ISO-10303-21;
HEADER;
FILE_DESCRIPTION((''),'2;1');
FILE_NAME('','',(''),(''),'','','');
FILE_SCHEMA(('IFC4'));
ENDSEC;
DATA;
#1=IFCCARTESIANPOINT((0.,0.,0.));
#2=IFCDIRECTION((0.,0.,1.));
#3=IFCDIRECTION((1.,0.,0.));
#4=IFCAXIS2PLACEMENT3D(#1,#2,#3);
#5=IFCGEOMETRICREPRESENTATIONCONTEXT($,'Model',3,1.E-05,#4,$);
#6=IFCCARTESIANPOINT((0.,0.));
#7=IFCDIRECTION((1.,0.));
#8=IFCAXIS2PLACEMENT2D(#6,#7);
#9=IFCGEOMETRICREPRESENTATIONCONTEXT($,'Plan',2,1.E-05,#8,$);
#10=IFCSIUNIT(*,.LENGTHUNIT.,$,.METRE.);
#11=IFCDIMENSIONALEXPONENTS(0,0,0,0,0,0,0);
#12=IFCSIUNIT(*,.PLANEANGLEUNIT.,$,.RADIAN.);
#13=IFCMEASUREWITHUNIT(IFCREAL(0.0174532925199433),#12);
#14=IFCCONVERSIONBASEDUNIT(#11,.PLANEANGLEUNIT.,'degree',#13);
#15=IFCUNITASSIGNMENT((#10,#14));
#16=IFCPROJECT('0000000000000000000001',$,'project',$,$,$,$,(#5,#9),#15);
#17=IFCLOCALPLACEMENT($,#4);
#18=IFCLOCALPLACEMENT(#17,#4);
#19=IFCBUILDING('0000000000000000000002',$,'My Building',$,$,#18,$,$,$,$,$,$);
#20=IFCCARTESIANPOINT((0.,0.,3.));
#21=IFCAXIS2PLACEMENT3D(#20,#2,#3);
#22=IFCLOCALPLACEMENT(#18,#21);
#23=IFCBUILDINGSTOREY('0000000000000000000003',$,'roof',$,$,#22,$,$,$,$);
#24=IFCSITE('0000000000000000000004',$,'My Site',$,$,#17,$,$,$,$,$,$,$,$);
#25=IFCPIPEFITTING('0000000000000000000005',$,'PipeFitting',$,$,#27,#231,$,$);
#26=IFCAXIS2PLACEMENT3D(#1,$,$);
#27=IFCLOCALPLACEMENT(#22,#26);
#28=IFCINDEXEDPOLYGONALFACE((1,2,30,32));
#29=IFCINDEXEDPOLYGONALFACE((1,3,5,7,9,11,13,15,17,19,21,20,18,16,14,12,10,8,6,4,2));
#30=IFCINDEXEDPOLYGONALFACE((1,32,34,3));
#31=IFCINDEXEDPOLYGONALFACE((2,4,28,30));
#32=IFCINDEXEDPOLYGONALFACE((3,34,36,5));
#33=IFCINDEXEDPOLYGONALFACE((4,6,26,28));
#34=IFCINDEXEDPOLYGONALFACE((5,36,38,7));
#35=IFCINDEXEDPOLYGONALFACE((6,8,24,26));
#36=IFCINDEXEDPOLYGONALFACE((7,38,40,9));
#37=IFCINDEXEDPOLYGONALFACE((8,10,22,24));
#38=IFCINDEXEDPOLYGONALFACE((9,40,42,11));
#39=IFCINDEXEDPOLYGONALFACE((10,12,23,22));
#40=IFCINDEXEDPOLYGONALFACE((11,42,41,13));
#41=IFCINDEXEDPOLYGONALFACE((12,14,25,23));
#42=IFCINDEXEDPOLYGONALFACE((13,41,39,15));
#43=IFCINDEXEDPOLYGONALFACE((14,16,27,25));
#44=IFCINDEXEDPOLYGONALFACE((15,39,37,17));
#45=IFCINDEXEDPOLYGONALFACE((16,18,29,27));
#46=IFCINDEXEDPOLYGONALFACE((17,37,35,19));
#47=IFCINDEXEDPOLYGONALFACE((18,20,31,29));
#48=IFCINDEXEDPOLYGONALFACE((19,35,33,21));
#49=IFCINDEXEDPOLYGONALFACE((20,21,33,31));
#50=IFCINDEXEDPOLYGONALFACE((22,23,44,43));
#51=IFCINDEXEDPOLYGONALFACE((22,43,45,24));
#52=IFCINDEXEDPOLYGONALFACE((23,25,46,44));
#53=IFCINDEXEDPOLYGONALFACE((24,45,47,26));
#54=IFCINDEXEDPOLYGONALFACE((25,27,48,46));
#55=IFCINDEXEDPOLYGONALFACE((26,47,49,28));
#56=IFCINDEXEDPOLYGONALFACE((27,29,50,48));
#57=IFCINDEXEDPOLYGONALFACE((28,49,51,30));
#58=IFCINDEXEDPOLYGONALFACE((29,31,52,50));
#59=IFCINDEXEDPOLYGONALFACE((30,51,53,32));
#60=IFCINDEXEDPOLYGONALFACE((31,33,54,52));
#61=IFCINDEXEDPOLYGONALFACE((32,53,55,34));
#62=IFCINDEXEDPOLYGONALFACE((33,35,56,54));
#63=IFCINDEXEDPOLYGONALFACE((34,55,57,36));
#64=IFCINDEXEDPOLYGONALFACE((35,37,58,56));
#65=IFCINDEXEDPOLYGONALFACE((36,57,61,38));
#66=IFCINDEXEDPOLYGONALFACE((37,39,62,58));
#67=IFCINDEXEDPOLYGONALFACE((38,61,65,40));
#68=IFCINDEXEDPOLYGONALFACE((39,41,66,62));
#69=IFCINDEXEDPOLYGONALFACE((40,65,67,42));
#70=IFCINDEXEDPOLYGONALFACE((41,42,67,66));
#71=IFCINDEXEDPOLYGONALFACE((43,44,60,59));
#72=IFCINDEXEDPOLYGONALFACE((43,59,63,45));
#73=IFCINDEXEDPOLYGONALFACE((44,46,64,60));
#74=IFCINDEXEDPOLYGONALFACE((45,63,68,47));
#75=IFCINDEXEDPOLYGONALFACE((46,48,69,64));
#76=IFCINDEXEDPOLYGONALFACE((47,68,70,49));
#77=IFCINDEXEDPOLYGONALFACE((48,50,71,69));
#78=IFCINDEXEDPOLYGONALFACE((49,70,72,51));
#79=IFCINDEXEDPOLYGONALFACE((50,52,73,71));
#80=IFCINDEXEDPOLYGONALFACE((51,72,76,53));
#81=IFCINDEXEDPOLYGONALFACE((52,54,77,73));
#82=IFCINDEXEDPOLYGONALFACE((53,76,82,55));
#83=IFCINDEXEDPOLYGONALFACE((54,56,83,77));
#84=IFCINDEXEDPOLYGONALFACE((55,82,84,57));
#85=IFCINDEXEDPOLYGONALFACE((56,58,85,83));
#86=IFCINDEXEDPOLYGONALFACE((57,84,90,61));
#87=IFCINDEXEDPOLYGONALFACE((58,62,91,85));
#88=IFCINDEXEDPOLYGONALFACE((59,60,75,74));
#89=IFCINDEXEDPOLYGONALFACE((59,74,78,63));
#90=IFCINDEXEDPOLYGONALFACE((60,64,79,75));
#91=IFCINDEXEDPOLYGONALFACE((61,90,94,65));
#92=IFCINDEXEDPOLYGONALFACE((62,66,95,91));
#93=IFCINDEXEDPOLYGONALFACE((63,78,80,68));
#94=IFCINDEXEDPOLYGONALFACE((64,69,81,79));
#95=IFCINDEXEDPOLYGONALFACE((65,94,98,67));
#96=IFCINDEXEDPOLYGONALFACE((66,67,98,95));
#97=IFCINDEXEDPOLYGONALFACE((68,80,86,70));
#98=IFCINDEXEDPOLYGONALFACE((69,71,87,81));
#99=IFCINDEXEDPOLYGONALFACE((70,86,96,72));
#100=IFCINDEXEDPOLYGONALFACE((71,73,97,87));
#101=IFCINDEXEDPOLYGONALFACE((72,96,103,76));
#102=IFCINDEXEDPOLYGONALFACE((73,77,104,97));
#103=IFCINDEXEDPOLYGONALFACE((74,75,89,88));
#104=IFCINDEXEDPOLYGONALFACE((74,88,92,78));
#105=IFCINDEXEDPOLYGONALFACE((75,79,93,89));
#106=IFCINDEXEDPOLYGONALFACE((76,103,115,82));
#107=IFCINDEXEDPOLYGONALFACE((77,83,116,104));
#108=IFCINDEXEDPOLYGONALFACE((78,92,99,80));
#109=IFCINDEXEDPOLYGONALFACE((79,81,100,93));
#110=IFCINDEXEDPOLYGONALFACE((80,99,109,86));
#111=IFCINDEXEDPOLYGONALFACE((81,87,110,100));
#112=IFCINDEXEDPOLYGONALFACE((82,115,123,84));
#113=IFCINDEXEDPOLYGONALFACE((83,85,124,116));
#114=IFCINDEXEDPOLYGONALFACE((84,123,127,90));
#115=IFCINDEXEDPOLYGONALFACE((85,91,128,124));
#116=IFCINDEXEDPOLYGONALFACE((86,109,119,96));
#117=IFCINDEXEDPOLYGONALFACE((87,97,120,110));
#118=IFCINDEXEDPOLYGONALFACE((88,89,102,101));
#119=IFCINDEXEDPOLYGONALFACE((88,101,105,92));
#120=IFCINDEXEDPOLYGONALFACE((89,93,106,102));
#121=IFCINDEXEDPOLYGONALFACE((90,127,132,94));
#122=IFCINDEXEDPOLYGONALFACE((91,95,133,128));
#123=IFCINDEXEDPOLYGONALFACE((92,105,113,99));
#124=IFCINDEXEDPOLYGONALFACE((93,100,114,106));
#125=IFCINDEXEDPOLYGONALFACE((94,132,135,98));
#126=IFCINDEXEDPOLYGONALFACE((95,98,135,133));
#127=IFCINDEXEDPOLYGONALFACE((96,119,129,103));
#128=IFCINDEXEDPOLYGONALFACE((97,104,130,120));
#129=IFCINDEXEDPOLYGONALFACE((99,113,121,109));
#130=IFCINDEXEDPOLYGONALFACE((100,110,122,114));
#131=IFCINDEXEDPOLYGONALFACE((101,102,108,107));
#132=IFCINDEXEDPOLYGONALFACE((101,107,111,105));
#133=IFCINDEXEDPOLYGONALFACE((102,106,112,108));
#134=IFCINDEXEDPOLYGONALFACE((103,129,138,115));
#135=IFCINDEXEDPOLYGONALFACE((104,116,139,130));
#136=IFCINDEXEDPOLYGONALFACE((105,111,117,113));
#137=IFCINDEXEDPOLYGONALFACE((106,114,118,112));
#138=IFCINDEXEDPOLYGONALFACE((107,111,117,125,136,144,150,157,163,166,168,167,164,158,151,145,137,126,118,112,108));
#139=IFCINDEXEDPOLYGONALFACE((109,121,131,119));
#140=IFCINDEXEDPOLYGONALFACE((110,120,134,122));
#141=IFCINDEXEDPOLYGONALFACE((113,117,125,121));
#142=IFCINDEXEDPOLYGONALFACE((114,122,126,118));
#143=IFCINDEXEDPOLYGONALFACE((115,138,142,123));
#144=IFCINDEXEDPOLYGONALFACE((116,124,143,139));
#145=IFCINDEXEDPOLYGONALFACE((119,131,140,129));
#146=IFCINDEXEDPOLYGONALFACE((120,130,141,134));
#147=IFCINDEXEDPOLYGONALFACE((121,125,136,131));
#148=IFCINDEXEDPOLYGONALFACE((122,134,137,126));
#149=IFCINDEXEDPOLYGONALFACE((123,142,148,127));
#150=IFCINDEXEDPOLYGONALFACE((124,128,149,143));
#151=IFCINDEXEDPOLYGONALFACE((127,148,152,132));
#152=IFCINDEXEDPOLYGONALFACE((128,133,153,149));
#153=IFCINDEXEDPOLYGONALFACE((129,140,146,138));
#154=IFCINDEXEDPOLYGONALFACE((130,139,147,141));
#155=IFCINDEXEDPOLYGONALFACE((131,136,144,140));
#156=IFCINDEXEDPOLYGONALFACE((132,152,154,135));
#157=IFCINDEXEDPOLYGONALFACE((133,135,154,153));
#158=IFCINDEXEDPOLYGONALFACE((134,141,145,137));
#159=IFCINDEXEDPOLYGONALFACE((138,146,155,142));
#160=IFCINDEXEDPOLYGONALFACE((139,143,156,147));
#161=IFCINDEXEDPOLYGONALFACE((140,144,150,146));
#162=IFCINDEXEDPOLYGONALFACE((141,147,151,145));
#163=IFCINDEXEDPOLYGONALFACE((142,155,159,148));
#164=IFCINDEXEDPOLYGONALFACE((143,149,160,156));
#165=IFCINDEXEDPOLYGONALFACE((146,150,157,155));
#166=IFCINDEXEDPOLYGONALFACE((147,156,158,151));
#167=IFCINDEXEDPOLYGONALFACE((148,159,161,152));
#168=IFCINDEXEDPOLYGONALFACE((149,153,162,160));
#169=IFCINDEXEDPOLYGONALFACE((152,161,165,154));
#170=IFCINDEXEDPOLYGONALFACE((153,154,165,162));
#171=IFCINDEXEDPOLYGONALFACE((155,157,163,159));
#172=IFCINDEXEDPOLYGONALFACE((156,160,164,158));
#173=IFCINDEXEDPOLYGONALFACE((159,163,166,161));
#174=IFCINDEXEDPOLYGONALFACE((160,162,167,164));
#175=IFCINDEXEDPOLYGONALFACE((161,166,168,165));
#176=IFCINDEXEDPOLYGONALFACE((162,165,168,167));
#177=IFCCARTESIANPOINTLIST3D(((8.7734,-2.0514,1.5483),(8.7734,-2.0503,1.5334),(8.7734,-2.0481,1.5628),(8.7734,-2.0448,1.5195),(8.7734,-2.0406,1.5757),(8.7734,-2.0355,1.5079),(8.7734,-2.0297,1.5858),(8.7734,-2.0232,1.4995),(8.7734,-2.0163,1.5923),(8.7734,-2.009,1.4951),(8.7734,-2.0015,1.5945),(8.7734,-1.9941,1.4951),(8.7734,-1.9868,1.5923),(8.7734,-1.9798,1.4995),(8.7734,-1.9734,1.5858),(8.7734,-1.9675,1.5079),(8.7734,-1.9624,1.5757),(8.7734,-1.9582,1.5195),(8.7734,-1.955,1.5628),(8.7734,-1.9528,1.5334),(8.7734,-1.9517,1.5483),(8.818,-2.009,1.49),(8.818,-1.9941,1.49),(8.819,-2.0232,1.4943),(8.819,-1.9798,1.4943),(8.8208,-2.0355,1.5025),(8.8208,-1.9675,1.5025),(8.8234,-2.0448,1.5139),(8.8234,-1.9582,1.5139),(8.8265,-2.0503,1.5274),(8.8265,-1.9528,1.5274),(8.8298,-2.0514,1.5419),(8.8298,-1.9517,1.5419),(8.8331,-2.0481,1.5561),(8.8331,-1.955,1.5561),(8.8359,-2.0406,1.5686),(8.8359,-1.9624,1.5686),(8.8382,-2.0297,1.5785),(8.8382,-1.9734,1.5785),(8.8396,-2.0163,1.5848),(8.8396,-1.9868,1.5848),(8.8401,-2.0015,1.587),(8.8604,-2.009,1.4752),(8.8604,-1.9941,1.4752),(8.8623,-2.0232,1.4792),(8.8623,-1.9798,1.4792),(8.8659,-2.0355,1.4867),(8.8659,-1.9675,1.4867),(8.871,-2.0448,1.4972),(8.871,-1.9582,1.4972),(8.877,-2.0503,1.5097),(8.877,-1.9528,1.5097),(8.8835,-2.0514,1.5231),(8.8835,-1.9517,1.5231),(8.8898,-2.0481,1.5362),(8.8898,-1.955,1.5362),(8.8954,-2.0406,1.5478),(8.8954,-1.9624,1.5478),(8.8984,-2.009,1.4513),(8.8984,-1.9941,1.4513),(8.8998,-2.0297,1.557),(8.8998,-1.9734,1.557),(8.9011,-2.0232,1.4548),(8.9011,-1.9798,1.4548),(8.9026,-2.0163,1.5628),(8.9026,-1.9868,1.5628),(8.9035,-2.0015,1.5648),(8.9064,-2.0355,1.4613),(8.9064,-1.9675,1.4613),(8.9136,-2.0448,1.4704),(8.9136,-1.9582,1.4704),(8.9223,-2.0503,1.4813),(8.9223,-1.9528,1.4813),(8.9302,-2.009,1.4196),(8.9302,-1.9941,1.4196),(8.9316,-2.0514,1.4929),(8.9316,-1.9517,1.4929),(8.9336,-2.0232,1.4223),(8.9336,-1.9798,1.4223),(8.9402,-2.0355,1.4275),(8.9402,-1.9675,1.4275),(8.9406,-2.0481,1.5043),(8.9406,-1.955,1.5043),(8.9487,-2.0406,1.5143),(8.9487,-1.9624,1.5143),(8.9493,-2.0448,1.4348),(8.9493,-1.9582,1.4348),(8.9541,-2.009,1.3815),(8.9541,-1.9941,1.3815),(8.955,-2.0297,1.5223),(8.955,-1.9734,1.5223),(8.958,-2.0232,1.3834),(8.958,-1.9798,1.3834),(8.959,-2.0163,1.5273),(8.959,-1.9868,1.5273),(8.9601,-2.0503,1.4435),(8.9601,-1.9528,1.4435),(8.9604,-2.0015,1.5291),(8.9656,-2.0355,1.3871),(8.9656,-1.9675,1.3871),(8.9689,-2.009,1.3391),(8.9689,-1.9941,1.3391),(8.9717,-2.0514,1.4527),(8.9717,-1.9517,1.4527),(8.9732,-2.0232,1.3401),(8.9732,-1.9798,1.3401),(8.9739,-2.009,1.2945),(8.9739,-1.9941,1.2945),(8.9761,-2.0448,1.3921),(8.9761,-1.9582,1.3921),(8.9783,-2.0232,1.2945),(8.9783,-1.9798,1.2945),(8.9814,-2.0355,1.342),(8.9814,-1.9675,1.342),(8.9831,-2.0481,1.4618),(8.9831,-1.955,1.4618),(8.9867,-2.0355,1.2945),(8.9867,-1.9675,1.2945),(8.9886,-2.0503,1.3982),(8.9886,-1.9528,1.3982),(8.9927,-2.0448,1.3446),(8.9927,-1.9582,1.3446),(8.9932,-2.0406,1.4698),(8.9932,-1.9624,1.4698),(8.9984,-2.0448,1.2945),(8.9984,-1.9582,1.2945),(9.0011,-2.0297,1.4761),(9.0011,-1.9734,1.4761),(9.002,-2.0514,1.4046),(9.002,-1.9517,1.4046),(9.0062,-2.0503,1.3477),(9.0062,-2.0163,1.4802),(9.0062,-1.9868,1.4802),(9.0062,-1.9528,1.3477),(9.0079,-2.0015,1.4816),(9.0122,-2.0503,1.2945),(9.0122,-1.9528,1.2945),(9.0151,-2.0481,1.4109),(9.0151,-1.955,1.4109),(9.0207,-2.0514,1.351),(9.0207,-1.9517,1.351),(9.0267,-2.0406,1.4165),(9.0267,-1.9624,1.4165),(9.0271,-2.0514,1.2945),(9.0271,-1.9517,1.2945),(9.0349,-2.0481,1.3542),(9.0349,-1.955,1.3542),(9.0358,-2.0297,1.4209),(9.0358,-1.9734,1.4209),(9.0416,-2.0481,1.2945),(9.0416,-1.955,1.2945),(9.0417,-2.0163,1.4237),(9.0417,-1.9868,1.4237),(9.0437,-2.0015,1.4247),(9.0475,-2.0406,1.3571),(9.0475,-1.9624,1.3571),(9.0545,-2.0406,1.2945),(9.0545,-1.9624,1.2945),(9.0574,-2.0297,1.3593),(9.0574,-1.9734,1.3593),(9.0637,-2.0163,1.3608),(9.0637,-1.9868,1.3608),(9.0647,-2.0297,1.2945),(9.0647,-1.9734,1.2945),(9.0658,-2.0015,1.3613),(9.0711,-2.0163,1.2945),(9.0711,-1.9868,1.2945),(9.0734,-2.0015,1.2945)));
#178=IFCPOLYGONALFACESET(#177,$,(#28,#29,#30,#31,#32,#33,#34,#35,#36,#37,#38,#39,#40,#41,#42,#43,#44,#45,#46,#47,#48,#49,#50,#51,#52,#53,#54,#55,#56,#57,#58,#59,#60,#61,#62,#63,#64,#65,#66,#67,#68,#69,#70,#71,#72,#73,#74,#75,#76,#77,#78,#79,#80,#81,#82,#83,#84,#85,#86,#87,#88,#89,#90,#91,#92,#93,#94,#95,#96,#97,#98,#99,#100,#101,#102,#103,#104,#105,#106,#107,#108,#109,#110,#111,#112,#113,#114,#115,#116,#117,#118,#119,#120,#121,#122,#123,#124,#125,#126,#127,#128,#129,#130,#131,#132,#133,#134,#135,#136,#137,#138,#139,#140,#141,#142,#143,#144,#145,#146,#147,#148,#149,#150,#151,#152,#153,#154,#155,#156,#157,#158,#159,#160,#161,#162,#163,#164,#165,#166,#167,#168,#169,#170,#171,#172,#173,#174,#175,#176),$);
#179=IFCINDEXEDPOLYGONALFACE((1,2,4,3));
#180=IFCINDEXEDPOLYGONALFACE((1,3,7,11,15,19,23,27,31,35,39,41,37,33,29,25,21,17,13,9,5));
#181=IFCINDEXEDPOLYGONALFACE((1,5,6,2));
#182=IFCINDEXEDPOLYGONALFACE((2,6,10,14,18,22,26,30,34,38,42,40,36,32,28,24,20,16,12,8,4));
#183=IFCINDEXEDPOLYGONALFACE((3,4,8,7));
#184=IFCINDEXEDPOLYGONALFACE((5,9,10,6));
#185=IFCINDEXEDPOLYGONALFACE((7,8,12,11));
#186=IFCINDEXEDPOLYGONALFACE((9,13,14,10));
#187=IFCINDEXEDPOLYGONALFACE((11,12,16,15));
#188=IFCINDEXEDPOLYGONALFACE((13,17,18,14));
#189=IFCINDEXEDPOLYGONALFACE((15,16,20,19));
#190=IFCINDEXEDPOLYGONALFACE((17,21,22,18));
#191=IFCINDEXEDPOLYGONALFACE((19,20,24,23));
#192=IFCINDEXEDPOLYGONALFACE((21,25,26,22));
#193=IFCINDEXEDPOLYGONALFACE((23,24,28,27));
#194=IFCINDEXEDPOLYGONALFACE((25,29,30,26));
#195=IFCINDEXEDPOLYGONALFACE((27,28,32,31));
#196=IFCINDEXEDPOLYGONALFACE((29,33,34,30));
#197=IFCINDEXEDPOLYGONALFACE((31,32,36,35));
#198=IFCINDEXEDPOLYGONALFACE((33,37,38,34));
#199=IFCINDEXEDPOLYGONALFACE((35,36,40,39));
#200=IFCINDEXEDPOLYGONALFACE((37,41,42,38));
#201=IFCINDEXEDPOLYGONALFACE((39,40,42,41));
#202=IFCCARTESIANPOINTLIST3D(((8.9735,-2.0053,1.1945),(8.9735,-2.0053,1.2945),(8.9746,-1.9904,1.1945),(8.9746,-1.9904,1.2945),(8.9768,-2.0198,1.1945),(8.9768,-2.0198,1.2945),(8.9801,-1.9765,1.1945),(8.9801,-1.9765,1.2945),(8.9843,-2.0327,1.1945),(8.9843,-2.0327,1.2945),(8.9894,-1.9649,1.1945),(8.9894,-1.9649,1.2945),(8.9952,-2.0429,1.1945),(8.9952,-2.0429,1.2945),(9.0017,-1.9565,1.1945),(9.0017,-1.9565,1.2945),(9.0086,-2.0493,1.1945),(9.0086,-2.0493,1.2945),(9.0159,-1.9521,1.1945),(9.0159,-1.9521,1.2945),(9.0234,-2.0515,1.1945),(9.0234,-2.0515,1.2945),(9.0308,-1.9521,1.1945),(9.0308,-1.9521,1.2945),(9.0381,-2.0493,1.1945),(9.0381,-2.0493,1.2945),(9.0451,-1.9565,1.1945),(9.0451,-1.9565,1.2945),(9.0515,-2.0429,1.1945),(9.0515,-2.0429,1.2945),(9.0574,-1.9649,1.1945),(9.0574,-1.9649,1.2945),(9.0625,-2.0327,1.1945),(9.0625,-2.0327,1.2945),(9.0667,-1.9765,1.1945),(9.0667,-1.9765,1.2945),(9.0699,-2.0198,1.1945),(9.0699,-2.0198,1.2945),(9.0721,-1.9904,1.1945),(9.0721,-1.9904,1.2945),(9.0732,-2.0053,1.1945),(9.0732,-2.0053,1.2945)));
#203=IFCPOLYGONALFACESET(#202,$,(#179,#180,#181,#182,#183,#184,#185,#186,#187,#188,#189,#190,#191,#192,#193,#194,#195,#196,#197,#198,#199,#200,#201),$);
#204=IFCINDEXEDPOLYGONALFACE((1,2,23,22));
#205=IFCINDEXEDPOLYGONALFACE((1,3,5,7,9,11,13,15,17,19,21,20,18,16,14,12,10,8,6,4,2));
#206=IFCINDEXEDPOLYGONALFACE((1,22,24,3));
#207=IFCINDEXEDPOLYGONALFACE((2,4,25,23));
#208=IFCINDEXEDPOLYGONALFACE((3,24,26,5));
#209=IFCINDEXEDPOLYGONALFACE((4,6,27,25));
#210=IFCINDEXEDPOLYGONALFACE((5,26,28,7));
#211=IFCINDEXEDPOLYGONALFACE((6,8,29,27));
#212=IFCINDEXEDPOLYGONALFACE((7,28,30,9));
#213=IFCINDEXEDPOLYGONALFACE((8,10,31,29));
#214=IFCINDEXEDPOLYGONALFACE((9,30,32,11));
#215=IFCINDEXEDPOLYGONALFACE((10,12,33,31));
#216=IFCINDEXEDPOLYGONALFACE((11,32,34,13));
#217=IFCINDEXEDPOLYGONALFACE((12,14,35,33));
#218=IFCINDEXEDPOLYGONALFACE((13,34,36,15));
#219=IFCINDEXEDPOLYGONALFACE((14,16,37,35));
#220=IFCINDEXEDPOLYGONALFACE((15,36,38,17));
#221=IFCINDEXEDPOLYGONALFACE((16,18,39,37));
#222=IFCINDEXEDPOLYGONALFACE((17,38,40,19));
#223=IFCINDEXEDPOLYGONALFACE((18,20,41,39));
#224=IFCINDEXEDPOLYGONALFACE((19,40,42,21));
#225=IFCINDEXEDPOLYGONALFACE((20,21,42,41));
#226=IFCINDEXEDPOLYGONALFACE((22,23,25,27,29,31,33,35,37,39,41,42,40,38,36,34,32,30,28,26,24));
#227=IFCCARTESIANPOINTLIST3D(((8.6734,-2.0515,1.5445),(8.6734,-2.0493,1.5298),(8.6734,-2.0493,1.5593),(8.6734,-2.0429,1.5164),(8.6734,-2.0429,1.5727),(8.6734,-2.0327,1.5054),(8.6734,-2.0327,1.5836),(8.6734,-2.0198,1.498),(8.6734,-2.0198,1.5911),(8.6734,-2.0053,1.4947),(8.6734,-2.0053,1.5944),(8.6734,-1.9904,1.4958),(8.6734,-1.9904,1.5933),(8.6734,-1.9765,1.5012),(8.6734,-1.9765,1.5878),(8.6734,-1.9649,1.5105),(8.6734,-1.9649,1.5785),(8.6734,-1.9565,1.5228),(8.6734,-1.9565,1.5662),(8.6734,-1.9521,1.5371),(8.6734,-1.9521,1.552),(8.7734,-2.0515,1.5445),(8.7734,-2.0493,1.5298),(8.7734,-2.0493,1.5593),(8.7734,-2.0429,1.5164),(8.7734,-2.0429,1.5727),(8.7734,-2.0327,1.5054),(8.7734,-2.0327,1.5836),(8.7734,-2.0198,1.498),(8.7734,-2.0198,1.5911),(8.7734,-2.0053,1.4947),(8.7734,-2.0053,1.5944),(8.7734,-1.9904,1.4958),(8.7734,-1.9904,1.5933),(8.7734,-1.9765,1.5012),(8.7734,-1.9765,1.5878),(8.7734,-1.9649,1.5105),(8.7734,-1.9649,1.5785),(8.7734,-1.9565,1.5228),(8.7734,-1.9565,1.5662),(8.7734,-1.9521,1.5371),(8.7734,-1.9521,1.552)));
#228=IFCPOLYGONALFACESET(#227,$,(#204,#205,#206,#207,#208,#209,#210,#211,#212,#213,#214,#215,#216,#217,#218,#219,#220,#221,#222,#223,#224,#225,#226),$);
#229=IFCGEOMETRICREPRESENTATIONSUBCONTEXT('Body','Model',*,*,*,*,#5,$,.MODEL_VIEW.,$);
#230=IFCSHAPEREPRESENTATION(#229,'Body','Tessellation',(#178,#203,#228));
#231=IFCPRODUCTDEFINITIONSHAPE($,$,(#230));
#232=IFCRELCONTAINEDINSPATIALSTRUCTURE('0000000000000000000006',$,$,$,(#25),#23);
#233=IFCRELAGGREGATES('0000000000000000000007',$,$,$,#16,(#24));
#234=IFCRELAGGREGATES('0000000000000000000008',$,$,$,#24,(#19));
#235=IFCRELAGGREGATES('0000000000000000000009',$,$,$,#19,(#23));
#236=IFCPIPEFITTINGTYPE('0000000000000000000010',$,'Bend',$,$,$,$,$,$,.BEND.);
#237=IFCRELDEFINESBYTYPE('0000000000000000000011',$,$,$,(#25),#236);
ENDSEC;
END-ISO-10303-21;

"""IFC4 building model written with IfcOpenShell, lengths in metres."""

from ifc_helpers import new_model, entity, si_unit, converted_unit, frame, origin_with_axes, origin_2d_with_axis, place, context, subcontext, project, spatial, circle, extrude, source, transform, mapped, type_object, type_shapes, element, save


model = new_model("IFC4")

# Units and contexts
model_context = context("Model", 3, precision=1e-05, world=origin_with_axes())
plan_context = context("Plan", 2, precision=1e-05, world=origin_2d_with_axis())
body_context = subcontext(model_context, "Body", "Model", "MODEL_VIEW")
ifc_project = project(units=[si_unit("LENGTHUNIT", "METRE"), converted_unit("PLANEANGLEUNIT", "degree", entity("IfcReal", 0.0174532925199433), si_unit("PLANEANGLEUNIT", "RADIAN"), dimensions=[0, 0, 0, 0, 0, 0, 0])], contexts=[model_context, plan_context])

# Site, building, storey
site_placement = place(None, origin_with_axes())
site = spatial("IfcSite", under=ifc_project, at=site_placement, Name="My Site")
building_placement = place(site_placement, origin_with_axes())
building = spatial("IfcBuilding", under=site, at=building_placement, Name="My Building")
storey_placement = place(building_placement, frame((0.0, 0.0, 3.0), z_axis=(0.0, 0.0, 1.0), x_axis=(1.0, 0.0, 0.0)))
storey = spatial("IfcBuildingStorey", under=building, at=storey_placement, Name="roof")

# Pipe fitting
pipe_fitting_type_1 = type_object("IfcPipeFittingType", Name="Bend", PredefinedType="BEND")
shared_shape = source(origin_with_axes(), body_context, "Body", "SolidModel", [
    entity("IfcSweptDiskSolid", entity("IfcIndexedPolyCurve", entity("IfcCartesianPointList3D", [[0.0, 0.0, 0.1], [0.0, -0.0732, 0.2768], [0.0, -0.25, 0.35]]), [entity("IfcArcIndex", [1, 2, 3])]), 0.05),
    extrude(circle(Radius=0.05), origin_with_axes(), (0.0, 0.0, 1.0), 0.1),
    extrude(circle(Radius=0.05), frame((0.0, -0.25, 0.35), z_axis=(0.0, -1.0, 0.0), x_axis=(1.0, 0.0, 0.0)), (0.0, 0.0, 1.0), 0.1),
])
type_shapes(pipe_fitting_type_1, [shared_shape])
for number, where, z_axis, x_axis, name in (
    (1, (9.0234, -2.0015, 1.1945), (0.000001, -0.000001, 1.0), (0.0, -1.0, -0.000001), "PipeFitting"),
):
    element("IfcPipeFitting", number, at=place(storey_placement, frame(where, z_axis=z_axis, x_axis=x_axis)), inside=storey, type_object=pipe_fitting_type_1, Name=name, context=body_context, shape_type="MappedRepresentation", body=[
        mapped(shared_shape, transform((0.0, 0.0, 0.0), x_axis=(1.0, 0.0, 0.0), y_axis=(0.0, 1.0, 0.0), z_axis=(0.0, 0.0, 1.0), scale=1.0)),
    ])

save(model, "model.ifc")
